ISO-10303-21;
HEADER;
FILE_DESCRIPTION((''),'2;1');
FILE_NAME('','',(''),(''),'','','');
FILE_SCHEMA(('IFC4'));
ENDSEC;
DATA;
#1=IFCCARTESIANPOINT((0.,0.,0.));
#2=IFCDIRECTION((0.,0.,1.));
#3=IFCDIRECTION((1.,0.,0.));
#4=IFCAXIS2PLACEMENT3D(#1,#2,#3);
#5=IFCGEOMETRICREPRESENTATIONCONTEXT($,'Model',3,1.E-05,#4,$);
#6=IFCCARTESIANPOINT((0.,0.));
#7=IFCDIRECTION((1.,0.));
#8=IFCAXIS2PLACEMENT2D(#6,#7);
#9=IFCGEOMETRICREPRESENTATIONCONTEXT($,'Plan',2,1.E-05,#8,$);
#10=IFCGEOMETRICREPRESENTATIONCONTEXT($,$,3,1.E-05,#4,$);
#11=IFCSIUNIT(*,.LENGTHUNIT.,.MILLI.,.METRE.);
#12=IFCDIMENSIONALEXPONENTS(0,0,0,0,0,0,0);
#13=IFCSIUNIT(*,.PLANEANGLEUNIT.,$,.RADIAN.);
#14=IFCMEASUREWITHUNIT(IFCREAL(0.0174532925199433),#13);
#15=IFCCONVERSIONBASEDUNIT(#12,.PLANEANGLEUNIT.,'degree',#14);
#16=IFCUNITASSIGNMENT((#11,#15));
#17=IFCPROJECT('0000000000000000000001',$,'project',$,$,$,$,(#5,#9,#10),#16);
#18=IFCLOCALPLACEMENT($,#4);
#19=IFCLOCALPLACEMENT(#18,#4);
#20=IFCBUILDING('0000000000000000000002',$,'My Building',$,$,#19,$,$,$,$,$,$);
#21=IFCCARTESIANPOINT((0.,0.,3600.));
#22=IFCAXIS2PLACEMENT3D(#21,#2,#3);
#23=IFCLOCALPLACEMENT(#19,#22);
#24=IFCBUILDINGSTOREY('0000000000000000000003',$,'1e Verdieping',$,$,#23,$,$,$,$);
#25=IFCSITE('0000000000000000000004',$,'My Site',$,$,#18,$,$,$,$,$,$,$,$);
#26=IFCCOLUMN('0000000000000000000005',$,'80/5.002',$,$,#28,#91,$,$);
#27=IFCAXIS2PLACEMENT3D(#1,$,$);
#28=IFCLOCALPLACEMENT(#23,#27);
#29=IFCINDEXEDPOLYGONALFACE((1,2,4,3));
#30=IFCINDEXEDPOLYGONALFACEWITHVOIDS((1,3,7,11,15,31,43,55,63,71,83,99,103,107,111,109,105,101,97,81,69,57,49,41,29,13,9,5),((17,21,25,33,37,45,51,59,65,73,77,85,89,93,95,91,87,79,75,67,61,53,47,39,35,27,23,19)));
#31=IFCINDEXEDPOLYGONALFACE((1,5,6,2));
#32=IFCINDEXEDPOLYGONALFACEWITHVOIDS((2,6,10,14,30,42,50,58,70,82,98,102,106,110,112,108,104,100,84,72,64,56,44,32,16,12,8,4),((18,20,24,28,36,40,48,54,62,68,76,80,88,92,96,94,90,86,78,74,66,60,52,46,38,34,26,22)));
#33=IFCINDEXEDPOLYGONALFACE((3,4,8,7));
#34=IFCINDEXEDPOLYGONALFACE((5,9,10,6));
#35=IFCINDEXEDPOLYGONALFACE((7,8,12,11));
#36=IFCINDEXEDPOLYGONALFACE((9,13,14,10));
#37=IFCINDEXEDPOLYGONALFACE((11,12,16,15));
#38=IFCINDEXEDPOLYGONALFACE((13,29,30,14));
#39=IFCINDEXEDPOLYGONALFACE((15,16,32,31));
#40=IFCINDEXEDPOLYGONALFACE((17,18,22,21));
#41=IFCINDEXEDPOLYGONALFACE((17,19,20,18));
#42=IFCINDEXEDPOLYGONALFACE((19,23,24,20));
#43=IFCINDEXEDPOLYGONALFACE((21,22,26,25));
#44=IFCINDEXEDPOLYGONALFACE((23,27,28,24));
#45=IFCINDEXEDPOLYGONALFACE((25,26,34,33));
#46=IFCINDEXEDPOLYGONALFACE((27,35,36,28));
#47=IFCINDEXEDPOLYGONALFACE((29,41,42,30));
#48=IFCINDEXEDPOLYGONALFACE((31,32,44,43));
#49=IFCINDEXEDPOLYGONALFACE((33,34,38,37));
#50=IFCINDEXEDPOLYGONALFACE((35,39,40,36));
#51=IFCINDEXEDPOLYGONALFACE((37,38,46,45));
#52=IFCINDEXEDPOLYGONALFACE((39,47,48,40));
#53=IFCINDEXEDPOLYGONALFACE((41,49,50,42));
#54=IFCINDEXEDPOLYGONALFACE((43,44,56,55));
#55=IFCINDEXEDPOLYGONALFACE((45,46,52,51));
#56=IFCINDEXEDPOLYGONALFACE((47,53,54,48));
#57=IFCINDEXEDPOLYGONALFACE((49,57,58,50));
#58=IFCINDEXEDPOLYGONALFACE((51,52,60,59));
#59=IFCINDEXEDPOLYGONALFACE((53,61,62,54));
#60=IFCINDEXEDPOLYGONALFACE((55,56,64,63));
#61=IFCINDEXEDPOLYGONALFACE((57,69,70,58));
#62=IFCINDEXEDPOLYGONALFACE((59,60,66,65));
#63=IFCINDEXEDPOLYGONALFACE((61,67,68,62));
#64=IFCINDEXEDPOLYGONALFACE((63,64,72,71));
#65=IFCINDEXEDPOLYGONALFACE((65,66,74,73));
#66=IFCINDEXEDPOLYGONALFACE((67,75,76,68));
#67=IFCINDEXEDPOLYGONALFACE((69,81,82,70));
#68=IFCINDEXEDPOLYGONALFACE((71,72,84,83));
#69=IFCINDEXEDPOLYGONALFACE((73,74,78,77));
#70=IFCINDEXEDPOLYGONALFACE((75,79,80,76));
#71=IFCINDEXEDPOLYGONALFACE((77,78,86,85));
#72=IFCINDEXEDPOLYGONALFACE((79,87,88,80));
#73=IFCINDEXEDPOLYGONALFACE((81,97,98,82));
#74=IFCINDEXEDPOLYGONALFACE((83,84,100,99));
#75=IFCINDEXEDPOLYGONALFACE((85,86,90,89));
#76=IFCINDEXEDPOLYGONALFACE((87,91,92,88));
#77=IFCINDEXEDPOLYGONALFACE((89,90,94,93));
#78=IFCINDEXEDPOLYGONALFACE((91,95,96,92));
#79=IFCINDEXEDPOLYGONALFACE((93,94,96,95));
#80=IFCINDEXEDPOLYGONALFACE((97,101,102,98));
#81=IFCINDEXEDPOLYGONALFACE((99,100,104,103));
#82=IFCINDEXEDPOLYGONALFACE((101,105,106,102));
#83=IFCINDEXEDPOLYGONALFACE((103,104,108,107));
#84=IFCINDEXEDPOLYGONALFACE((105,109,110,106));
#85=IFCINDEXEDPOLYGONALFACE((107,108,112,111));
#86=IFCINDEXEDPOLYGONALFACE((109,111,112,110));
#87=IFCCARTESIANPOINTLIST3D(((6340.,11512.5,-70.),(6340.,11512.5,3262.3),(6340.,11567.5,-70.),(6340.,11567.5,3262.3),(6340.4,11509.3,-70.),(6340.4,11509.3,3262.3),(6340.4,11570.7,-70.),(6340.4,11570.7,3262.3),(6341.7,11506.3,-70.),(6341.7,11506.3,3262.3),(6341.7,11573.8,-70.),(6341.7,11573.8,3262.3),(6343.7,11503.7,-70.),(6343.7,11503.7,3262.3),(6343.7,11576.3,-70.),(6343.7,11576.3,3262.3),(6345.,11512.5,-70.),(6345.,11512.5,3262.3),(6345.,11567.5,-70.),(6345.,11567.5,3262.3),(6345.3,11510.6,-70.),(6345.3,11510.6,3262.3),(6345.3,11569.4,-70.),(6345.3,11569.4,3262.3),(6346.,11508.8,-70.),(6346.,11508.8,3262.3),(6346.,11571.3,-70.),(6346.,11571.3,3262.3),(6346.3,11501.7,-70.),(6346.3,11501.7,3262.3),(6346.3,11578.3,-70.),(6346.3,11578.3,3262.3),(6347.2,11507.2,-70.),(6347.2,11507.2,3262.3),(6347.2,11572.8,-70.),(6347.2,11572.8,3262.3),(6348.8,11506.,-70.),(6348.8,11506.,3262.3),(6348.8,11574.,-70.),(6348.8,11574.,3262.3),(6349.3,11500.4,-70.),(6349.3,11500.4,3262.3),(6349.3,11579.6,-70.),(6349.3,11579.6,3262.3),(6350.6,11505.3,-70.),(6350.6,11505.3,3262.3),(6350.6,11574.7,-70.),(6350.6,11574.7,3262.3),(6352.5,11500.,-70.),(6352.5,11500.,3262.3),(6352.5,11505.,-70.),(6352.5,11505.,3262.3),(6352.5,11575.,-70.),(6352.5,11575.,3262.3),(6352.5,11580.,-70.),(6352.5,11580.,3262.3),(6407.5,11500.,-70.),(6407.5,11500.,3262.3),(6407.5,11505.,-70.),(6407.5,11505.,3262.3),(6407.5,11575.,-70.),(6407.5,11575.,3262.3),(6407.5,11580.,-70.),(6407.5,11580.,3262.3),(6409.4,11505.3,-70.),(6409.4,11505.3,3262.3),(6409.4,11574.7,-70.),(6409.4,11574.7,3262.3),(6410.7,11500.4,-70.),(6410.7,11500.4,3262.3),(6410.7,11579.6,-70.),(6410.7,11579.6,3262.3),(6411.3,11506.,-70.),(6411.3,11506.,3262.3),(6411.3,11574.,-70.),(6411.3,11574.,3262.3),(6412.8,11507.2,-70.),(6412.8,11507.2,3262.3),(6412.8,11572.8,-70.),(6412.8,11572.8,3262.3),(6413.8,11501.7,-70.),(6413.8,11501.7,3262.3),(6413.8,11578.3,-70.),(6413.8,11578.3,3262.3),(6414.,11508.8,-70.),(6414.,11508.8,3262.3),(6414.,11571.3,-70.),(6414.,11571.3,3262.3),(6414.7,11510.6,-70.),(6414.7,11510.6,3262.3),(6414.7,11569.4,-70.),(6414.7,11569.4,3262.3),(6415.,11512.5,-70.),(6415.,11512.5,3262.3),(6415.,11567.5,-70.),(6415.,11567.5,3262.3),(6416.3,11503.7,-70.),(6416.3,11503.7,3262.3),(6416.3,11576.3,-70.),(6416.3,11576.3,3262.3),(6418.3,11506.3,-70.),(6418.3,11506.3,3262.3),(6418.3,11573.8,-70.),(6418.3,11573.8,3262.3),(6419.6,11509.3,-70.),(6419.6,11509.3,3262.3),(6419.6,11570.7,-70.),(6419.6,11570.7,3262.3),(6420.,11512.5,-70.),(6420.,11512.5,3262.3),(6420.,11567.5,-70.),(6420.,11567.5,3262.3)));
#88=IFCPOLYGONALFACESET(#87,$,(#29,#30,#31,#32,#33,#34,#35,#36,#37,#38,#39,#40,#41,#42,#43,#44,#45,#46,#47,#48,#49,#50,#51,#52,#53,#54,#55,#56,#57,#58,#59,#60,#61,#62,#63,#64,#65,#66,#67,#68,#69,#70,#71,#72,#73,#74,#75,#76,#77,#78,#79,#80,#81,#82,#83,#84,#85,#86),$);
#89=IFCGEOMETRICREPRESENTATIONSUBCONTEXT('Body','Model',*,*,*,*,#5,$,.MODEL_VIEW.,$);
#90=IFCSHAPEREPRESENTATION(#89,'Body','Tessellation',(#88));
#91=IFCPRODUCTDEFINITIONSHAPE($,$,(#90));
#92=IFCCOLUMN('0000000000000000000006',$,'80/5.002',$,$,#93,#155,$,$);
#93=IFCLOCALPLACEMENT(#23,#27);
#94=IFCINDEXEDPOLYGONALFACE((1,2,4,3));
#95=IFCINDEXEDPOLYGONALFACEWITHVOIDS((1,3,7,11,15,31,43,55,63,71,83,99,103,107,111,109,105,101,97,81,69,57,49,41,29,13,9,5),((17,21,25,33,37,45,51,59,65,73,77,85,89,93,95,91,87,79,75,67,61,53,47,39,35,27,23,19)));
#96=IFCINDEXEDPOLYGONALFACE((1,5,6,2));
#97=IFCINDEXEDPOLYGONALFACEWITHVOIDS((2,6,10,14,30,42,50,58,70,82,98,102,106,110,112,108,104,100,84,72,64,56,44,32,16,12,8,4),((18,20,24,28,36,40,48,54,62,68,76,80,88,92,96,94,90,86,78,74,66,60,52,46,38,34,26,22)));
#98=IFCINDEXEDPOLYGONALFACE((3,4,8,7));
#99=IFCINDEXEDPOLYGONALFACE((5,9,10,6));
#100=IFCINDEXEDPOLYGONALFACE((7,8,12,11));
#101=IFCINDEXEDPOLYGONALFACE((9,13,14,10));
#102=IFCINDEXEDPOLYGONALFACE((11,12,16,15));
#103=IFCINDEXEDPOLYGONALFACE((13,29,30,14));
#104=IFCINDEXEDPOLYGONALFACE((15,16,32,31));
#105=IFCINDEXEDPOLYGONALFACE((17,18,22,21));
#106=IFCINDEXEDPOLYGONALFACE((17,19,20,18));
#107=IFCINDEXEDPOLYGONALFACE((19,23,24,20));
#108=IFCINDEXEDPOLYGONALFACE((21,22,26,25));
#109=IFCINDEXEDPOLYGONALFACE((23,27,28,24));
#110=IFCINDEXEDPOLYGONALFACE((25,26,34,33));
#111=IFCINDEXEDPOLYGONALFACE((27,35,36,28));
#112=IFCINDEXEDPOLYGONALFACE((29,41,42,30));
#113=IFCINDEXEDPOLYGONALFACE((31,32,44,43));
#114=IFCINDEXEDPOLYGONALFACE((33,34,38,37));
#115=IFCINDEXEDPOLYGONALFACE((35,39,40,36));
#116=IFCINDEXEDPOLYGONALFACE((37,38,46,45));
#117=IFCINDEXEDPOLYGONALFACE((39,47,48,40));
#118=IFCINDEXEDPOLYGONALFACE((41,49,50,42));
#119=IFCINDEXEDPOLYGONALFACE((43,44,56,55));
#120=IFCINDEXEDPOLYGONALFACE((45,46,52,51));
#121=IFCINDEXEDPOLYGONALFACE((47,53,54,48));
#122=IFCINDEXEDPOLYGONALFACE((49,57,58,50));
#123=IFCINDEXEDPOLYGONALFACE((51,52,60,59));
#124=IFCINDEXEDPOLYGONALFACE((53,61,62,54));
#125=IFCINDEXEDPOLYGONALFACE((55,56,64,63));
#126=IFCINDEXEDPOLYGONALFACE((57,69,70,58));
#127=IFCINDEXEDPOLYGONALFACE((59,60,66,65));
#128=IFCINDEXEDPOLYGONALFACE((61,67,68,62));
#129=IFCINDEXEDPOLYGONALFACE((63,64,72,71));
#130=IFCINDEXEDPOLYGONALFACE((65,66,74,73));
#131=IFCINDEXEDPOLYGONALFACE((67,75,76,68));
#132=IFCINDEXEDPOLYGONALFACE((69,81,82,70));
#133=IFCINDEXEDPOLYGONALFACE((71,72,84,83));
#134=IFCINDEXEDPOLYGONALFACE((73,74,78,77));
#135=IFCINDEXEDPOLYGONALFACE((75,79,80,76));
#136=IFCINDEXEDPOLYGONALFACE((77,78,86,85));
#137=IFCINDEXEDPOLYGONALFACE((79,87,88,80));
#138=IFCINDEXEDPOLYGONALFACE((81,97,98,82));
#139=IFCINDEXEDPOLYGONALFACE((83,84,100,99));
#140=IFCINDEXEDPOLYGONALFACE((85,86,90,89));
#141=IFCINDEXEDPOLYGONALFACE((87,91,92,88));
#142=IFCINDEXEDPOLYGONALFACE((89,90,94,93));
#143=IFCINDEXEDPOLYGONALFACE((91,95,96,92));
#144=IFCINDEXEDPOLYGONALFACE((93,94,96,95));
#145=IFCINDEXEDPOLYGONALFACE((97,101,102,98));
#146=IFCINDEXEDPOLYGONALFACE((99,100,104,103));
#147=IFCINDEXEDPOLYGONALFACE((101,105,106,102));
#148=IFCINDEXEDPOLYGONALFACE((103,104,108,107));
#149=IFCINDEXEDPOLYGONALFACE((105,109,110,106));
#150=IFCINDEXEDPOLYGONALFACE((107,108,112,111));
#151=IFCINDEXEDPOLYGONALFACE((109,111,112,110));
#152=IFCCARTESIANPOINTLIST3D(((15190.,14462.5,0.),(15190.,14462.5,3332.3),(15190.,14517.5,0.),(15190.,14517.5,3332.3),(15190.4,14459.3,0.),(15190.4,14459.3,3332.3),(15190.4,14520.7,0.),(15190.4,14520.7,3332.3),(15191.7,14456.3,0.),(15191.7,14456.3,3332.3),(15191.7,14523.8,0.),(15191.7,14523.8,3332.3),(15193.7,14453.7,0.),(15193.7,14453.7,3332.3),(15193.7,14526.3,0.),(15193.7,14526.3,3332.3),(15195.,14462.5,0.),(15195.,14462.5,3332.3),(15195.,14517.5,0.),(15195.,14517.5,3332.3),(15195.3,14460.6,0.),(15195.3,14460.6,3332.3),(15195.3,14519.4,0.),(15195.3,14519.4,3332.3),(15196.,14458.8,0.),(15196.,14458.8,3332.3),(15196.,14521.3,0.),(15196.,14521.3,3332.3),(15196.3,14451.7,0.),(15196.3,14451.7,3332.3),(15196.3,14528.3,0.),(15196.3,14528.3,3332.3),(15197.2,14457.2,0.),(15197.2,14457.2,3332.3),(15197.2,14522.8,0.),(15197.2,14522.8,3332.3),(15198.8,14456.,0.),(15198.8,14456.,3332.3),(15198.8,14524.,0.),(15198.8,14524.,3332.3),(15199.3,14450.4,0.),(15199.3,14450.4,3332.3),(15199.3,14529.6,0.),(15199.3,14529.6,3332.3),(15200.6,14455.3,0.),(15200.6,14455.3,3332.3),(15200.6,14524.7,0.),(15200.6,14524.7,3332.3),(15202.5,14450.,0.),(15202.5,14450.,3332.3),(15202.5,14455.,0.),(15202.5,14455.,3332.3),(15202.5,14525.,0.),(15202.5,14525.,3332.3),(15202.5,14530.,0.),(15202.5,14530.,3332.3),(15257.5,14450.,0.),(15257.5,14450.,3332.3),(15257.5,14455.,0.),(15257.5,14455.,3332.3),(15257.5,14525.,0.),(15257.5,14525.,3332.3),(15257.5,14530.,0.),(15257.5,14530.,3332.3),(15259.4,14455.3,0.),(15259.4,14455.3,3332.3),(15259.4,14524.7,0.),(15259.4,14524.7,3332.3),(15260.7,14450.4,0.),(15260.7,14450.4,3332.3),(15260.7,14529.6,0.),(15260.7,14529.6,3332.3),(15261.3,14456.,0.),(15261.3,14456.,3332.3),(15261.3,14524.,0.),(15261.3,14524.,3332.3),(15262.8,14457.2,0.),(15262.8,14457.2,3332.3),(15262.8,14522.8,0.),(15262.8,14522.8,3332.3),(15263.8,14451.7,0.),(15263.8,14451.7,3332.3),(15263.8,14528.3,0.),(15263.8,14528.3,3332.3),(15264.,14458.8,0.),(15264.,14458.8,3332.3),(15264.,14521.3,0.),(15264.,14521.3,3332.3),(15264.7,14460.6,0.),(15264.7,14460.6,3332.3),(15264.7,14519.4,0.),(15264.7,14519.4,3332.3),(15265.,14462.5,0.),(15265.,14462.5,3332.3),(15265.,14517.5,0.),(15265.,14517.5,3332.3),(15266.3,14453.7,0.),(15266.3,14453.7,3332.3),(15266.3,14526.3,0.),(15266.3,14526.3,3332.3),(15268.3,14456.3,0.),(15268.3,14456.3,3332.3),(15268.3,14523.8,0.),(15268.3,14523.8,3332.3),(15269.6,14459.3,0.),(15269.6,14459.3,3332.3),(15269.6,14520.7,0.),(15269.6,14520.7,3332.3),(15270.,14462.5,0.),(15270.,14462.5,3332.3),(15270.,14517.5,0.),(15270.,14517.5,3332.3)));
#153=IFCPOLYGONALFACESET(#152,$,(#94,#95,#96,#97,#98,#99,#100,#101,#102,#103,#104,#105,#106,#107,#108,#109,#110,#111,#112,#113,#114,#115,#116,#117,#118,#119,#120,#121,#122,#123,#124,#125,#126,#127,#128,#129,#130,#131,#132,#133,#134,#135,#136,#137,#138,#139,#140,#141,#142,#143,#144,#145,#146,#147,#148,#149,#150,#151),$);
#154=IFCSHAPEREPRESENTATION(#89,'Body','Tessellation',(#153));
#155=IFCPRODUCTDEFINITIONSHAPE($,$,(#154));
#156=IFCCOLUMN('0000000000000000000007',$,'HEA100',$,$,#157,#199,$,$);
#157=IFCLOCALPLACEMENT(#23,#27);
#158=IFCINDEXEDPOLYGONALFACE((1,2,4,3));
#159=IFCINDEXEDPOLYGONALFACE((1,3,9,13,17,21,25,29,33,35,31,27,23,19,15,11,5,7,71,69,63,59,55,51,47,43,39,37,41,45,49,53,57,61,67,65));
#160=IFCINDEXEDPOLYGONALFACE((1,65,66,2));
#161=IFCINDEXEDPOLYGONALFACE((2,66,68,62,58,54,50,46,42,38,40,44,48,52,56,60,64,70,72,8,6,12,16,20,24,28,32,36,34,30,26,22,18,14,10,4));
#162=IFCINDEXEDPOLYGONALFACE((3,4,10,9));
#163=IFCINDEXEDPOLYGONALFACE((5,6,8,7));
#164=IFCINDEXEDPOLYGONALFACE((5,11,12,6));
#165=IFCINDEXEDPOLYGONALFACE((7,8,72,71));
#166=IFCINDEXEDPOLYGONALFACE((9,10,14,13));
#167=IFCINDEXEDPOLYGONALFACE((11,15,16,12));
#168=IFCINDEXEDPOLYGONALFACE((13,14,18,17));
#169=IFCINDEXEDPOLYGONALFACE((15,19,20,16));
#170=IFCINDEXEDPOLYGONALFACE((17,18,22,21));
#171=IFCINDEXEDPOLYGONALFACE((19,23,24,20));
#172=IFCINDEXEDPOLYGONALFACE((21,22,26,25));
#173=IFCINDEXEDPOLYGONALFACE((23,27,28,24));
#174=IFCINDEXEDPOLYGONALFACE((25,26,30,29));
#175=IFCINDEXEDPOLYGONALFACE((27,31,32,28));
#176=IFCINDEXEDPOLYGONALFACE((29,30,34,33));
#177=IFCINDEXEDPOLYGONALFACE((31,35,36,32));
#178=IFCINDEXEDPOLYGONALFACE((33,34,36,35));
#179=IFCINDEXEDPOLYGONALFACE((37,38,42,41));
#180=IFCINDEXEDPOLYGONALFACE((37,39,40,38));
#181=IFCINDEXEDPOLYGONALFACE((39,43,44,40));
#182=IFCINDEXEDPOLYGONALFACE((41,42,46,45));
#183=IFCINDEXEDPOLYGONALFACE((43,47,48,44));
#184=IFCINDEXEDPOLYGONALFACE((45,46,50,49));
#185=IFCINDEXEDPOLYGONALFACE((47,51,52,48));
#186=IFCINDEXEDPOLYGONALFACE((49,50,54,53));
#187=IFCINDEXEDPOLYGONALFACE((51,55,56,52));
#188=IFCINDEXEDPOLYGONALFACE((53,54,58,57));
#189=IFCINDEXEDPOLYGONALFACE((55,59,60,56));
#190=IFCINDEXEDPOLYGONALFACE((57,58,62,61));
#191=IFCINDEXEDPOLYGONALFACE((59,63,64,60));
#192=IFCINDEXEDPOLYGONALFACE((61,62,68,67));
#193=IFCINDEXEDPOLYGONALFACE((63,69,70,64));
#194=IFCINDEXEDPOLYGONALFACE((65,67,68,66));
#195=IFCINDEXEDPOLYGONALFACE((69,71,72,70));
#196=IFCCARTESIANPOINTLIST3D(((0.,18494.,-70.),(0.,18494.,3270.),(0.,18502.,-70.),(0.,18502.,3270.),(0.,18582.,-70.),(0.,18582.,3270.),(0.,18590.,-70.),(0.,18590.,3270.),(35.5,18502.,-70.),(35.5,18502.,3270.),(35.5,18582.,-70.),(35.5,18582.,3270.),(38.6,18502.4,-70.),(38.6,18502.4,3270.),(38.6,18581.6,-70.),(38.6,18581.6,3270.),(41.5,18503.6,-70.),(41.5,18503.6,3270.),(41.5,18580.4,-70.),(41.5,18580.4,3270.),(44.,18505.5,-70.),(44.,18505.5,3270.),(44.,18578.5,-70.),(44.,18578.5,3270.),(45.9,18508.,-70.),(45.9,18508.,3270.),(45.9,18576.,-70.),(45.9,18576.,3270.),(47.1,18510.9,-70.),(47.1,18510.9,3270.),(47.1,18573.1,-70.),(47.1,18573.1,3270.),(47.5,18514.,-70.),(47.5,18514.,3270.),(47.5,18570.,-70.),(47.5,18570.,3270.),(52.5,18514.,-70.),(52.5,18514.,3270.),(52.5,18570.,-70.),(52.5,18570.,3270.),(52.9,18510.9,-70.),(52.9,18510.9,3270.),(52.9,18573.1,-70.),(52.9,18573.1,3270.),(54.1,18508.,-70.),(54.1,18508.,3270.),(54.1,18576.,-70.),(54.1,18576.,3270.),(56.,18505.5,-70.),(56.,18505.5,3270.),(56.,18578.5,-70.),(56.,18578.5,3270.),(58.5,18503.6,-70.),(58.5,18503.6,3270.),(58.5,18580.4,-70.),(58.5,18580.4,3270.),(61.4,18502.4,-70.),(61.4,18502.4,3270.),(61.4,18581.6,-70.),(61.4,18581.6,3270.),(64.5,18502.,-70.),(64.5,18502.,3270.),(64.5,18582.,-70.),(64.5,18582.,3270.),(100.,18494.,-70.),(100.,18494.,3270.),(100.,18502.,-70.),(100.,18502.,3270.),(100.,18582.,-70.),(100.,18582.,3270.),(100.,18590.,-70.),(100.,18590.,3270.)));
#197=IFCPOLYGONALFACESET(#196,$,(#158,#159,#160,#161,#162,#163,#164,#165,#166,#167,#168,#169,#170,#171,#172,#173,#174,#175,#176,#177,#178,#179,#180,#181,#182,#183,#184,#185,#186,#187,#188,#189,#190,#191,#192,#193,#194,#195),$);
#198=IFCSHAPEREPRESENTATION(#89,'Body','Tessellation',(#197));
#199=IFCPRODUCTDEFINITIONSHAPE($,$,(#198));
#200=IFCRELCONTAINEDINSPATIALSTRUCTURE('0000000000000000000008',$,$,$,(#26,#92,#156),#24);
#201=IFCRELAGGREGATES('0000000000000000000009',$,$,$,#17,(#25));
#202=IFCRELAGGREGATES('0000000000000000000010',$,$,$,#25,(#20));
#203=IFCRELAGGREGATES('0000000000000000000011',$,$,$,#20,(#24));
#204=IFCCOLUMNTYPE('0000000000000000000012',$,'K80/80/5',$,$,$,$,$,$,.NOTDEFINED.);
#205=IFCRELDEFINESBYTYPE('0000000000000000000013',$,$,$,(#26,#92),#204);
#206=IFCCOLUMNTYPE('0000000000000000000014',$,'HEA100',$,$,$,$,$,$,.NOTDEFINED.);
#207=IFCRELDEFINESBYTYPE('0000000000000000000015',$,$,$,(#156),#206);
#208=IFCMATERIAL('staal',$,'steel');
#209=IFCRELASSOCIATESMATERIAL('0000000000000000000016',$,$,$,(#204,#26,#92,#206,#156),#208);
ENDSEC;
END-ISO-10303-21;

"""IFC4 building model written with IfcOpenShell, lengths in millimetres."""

from ifc_helpers import new_model, entity, si_unit, converted_unit, frame, origin_with_axes, origin_2d_with_axis, place, context, subcontext, project, spatial, hollow_rectangle, i_section, extrude, material, material_profile, profile_set, profile_usage, type_object, element, save


model = new_model("IFC4")

# Units and contexts
model_context = context("Model", 3, precision=1e-05, world=origin_with_axes())
plan_context = context("Plan", 2, precision=1e-05, world=origin_2d_with_axis())
context_of_model = context(None, 3, precision=1e-05, world=origin_with_axes())
body_context = subcontext(model_context, "Body", "Model", "MODEL_VIEW")
ifc_project = project(units=[si_unit("LENGTHUNIT", "METRE", prefix="MILLI"), converted_unit("PLANEANGLEUNIT", "degree", entity("IfcReal", 0.0174532925199433), si_unit("PLANEANGLEUNIT", "RADIAN"), dimensions=[0, 0, 0, 0, 0, 0, 0])], contexts=[model_context, plan_context, context_of_model])

# Site, building, storey
site_placement = place(None, origin_with_axes())
site = spatial("IfcSite", under=ifc_project, at=site_placement, Name="My Site")
building_placement = place(site_placement, origin_with_axes())
building = spatial("IfcBuilding", under=site, at=building_placement, Name="My Building")
storey_placement = place(building_placement, frame((0.0, 0.0, 3600.0), z_axis=(0.0, 0.0, 1.0), x_axis=(1.0, 0.0, 0.0)))
storey = spatial("IfcBuildingStorey", under=building, at=storey_placement, Name="1e Verdieping")

# Columns
ifc_material_1 = material(Name="staal", Category="steel")
ifc_material_profile_1 = material_profile(ifc_material_1, hollow_rectangle(XDim=80.0, YDim=80.0, WallThickness=5.0, InnerFilletRadius=7.5, OuterFilletRadius=12.5))
ifc_profile_set_1 = profile_set([ifc_material_profile_1], Name="K80/80/5")
column_type_1 = type_object("IfcColumnType", Name="K80/80/5", PredefinedType="NOTDEFINED", material=ifc_profile_set_1)
ifc_profile_usage_1 = profile_usage(ifc_profile_set_1)
column_1_placement = place(storey_placement, frame((6380.0, 11540.0, -70.0), z_axis=(0.0, 0.0, 1.0), x_axis=(1.0, 0.0, 0.0)))
element("IfcColumn", 1, at=column_1_placement, inside=storey, type_object=column_type_1, material=ifc_profile_usage_1, Name="80/5.002", context=body_context, shape_type="SweptSolid", body=[
    extrude(hollow_rectangle(XDim=80.0, YDim=80.0, WallThickness=5.0, InnerFilletRadius=7.5, OuterFilletRadius=12.5), origin_with_axes(), (0.0, 0.0, 1.0), 3332.3),
])
ifc_profile_usage_2 = profile_usage(ifc_profile_set_1)
column_2_placement = place(storey_placement, frame((15230.0, 14490.0, 0.0), z_axis=(0.0, 0.0, 1.0), x_axis=(1.0, 0.0, 0.0)))
element("IfcColumn", 2, at=column_2_placement, inside=storey, type_object=column_type_1, material=ifc_profile_usage_2, Name="80/5.002", context=body_context, shape_type="SweptSolid", body=[
    extrude(hollow_rectangle(XDim=80.0, YDim=80.0, WallThickness=5.0, InnerFilletRadius=7.5, OuterFilletRadius=12.5), origin_with_axes(), (0.0, 0.0, 1.0), 3332.3),
])
ifc_material_profile_2 = material_profile(ifc_material_1, i_section(OverallWidth=100.0, OverallDepth=96.0, WebThickness=5.0, FlangeThickness=8.0, FilletRadius=12.0))
ifc_profile_set_2 = profile_set([ifc_material_profile_2], Name="HEA100")
ifc_profile_usage_3 = profile_usage(ifc_profile_set_2)
column_type_2 = type_object("IfcColumnType", Name="HEA100", PredefinedType="NOTDEFINED", material=ifc_profile_set_2)
column_3_placement = place(storey_placement, frame((50.0, 18542.0, -70.0), z_axis=(0.0, 0.0, 1.0), x_axis=(1.0, 0.0, 0.0)))
element("IfcColumn", 3, at=column_3_placement, inside=storey, type_object=column_type_2, material=ifc_profile_usage_3, Name="HEA100", context=body_context, shape_type="SweptSolid", body=[
    extrude(i_section(OverallWidth=100.0, OverallDepth=96.0, WebThickness=5.0, FlangeThickness=8.0, FilletRadius=12.0), origin_with_axes(), (0.0, 0.0, 1.0), 3340.0),
])

save(model, "model.ifc")
